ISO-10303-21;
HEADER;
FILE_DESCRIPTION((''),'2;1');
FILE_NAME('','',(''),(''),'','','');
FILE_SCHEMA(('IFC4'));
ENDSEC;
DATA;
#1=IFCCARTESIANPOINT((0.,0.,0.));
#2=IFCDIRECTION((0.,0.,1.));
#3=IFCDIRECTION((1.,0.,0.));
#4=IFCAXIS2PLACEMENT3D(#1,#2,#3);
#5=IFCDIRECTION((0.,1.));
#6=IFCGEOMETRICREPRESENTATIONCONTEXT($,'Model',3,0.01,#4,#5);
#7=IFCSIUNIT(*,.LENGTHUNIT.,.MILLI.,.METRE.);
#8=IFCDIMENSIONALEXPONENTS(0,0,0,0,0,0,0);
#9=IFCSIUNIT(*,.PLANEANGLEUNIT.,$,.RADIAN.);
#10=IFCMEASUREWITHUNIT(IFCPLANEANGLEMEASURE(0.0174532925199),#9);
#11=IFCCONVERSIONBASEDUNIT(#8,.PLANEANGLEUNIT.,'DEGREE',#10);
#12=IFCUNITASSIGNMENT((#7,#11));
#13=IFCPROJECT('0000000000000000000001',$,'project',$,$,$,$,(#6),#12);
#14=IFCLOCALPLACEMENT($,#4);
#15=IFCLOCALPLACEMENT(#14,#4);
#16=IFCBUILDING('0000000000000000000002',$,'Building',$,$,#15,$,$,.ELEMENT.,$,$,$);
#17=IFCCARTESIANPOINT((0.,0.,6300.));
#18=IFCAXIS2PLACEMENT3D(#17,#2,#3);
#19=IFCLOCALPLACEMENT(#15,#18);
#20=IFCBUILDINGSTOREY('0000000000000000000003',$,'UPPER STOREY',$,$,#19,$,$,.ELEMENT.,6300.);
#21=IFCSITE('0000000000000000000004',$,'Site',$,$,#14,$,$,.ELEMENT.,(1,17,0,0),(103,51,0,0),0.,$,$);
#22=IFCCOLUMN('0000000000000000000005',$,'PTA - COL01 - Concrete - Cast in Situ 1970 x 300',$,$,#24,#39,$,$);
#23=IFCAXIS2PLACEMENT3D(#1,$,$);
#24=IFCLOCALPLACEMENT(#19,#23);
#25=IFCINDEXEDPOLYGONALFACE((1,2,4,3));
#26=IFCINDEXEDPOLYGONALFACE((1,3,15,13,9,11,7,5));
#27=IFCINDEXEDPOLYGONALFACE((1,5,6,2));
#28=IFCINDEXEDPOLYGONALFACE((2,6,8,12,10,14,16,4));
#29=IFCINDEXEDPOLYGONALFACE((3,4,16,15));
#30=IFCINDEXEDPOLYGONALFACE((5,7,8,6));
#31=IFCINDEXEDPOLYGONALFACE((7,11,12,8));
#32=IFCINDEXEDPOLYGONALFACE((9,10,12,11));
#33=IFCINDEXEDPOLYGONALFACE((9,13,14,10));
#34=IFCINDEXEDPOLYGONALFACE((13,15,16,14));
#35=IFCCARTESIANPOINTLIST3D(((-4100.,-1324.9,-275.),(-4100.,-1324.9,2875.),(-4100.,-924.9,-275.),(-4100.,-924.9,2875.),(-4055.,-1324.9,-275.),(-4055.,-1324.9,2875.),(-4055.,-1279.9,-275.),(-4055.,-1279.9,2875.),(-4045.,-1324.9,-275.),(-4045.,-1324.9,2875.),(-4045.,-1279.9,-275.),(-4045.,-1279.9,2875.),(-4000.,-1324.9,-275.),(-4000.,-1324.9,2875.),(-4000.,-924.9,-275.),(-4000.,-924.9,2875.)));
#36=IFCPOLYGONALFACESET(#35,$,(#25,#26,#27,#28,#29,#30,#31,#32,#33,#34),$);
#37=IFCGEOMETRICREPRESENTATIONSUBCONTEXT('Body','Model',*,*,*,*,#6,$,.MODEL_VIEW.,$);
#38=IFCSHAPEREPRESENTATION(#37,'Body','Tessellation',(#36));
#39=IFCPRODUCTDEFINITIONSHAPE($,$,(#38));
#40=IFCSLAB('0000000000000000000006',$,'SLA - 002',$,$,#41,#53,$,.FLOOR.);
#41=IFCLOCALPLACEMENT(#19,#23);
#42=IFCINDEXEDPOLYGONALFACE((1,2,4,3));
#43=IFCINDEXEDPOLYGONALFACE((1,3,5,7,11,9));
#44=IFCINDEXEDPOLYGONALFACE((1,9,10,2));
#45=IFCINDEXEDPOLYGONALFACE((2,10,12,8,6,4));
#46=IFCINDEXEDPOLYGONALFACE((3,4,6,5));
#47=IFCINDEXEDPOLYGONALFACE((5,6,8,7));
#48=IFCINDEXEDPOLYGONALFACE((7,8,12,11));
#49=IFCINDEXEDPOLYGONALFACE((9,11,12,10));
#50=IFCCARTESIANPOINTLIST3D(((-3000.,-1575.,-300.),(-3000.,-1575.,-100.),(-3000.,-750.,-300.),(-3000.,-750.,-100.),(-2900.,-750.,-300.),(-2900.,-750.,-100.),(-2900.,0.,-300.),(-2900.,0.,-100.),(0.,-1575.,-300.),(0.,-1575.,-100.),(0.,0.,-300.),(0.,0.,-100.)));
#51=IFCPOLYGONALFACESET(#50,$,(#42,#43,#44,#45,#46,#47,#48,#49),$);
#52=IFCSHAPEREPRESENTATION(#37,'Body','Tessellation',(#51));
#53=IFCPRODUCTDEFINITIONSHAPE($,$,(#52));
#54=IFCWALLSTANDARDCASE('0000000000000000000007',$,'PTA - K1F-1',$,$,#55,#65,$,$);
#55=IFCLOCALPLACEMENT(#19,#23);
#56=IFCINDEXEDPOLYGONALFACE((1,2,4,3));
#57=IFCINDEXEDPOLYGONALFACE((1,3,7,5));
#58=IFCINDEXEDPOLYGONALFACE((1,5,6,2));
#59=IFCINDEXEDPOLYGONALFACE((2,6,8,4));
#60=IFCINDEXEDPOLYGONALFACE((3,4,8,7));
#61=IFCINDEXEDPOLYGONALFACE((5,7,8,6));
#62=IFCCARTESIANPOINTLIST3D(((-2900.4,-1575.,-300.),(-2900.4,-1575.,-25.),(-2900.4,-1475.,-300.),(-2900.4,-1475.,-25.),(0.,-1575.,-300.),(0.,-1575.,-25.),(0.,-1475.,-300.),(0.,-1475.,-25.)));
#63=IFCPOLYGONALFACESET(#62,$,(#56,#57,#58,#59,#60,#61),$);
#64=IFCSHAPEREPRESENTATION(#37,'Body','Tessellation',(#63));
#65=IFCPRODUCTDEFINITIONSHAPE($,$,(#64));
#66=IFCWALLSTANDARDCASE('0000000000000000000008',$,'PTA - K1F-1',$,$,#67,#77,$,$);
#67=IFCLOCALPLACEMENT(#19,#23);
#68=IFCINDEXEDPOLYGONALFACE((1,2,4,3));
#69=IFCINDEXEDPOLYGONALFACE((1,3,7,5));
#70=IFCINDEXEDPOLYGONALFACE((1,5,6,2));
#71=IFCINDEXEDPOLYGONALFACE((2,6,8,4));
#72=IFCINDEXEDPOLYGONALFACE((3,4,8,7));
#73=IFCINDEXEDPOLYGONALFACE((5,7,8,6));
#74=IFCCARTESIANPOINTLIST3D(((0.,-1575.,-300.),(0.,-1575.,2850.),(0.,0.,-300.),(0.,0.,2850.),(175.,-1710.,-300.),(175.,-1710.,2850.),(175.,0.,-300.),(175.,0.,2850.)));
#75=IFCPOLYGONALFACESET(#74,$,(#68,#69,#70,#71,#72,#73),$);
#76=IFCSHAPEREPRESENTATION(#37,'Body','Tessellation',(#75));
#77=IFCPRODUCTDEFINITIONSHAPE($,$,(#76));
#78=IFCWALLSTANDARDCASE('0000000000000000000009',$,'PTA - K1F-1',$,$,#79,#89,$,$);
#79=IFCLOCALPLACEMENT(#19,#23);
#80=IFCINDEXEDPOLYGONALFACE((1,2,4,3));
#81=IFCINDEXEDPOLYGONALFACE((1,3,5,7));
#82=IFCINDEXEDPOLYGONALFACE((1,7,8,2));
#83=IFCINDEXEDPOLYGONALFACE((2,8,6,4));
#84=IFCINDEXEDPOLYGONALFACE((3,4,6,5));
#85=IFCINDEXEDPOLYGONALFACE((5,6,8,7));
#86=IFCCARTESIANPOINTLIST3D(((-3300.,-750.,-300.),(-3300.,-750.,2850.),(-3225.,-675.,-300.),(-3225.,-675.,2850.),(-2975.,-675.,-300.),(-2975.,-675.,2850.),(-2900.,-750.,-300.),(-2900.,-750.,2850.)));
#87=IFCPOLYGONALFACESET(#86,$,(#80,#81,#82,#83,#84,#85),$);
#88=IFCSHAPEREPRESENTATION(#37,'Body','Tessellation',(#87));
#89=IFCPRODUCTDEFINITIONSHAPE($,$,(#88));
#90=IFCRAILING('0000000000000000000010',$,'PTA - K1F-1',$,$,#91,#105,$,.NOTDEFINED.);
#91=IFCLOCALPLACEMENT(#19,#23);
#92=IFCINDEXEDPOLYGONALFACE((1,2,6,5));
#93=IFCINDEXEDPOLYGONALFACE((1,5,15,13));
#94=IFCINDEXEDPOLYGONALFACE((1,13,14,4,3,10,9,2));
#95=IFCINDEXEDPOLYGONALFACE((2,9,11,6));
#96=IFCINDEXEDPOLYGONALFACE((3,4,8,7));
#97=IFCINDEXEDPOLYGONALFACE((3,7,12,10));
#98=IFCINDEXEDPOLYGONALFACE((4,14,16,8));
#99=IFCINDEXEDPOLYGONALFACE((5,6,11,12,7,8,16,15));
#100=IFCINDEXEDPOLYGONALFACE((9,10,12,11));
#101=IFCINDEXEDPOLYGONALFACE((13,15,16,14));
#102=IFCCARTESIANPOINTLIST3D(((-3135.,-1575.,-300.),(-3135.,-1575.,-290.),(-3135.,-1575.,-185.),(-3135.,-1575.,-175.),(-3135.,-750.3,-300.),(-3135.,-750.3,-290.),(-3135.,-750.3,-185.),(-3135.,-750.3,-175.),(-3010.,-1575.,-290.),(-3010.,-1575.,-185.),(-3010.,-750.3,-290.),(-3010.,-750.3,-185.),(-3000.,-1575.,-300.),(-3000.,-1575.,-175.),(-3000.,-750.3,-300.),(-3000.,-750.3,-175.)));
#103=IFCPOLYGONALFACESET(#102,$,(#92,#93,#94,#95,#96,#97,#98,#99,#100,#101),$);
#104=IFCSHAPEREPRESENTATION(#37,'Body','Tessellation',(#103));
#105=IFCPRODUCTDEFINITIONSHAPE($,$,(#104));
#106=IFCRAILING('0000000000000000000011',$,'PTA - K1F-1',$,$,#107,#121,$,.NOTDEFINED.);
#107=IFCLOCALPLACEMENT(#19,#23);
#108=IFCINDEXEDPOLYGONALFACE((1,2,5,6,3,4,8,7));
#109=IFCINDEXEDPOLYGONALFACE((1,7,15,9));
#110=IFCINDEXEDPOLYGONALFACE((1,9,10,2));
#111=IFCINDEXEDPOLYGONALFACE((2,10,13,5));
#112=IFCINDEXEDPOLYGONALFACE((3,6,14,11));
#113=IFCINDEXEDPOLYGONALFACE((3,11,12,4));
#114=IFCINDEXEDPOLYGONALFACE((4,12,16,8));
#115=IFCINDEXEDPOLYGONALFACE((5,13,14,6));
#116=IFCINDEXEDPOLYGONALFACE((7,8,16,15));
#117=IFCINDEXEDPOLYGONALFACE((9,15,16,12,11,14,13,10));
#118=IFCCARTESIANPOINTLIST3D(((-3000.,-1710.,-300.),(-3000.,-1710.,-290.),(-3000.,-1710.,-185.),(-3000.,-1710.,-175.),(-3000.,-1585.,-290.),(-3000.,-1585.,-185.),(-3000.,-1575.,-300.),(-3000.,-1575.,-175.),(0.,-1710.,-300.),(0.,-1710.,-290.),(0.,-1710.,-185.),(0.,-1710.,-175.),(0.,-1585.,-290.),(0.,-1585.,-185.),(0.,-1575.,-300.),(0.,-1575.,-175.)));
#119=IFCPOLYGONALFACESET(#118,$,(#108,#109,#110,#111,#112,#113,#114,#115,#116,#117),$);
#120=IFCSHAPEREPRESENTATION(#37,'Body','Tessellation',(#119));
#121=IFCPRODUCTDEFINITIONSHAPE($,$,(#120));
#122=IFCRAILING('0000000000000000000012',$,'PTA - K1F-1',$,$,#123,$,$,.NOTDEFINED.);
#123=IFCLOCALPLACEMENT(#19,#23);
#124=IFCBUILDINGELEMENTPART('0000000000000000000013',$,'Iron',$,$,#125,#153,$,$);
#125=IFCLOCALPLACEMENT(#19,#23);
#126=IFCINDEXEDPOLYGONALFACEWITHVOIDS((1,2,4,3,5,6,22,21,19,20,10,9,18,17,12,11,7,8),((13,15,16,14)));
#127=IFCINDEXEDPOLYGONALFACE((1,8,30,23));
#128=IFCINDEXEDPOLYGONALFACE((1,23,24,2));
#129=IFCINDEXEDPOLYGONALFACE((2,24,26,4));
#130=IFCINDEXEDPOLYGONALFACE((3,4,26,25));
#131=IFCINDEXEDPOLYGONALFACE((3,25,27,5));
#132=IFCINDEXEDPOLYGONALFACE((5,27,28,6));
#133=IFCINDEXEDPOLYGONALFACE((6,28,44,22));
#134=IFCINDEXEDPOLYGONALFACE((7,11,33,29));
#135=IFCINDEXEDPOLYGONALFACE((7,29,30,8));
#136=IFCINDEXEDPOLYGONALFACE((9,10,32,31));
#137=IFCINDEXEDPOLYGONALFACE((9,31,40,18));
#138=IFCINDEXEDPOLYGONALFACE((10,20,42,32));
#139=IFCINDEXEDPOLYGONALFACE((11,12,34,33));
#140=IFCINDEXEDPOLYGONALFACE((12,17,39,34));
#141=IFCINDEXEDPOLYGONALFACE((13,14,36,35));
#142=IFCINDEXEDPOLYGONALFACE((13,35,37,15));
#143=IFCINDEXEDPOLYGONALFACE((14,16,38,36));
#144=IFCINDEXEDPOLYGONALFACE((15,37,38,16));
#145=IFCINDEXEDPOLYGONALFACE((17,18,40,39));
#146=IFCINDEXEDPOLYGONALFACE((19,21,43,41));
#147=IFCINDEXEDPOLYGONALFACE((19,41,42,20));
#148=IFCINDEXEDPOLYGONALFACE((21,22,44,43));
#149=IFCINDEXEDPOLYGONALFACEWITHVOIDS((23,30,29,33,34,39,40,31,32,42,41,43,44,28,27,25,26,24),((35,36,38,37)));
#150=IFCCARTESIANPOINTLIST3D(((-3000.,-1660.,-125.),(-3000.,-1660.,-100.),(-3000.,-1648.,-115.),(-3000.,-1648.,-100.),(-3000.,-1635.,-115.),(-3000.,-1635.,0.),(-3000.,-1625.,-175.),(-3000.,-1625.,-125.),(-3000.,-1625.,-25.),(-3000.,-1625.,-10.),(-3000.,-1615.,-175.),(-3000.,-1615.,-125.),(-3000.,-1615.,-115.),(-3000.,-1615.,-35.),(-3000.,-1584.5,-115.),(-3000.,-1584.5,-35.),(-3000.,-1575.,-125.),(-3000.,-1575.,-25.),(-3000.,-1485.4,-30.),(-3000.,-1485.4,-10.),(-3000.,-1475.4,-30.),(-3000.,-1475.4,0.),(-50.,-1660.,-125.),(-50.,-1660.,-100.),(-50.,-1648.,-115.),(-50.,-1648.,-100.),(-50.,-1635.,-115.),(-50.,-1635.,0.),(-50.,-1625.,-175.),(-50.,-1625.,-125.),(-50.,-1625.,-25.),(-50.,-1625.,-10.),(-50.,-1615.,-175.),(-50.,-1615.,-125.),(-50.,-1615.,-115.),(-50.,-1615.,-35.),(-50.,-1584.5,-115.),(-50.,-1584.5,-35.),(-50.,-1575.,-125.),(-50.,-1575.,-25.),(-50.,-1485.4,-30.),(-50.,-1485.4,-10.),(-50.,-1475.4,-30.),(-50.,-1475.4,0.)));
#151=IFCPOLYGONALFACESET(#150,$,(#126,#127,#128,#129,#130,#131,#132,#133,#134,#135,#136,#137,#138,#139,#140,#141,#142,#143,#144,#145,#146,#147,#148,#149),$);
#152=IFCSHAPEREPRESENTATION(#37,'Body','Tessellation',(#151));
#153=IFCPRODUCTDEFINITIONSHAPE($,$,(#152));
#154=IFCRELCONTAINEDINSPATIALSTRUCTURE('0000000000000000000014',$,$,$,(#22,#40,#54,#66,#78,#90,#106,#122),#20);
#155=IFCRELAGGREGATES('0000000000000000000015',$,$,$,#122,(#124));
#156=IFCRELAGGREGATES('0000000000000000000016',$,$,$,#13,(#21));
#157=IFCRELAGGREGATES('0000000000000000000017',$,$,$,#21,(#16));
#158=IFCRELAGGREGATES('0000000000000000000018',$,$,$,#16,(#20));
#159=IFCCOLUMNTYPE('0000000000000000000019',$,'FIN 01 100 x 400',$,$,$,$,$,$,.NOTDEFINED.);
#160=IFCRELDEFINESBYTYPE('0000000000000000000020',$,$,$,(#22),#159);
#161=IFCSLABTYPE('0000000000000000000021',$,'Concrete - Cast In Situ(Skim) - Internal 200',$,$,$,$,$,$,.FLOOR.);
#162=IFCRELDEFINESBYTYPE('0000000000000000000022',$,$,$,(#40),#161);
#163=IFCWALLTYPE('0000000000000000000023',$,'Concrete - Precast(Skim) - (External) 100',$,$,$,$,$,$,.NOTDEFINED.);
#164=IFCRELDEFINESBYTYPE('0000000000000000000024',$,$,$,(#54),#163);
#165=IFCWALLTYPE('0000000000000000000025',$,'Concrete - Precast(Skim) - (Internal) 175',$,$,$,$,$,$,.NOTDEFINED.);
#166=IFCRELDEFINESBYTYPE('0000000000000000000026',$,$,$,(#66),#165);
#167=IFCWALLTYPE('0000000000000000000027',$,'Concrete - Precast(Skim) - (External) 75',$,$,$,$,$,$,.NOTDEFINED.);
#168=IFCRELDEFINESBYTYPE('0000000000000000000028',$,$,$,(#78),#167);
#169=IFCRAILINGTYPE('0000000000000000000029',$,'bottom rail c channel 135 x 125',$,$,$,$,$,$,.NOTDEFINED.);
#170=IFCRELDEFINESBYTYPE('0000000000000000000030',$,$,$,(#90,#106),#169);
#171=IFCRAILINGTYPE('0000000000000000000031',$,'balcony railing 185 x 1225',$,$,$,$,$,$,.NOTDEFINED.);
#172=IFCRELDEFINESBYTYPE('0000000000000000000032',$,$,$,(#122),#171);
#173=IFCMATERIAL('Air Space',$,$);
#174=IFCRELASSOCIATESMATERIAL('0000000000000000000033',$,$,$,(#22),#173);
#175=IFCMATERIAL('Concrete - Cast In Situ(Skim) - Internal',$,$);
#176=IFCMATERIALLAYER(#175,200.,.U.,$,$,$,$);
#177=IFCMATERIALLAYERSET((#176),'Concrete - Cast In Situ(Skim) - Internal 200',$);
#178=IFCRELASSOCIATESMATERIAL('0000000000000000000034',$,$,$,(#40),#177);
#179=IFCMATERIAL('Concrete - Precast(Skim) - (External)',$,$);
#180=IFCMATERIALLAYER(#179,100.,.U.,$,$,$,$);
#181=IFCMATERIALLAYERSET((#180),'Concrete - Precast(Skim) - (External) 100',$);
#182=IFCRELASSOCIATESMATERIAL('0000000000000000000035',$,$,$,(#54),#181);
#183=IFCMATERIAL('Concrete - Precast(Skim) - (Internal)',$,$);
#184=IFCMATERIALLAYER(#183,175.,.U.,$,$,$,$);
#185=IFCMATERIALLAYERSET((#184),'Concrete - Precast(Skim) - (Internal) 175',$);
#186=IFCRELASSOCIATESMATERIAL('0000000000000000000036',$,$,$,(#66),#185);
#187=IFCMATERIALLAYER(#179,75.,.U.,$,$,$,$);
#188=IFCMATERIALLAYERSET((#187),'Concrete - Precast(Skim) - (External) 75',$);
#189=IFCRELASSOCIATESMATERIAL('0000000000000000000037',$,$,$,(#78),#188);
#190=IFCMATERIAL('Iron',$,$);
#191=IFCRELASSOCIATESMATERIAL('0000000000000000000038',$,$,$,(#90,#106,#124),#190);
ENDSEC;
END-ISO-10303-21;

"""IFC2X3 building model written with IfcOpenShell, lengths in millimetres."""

from ifc_helpers import new_model, entity, si_unit, converted_unit, direction, frame, origin_with_axes, place, context, subcontext, project, spatial, polyline, outline, extrude, material, layer, layer_set, layer_usage, type_object, element, aggregate, save


model = new_model("IFC2X3")

# Units and contexts
model_context = context("Model", 3, precision=0.01, world=origin_with_axes(), true_north=direction((0.0, 1.0)))
body_context = subcontext(model_context, "Body", "Model", "MODEL_VIEW")
ifc_project = project(units=[si_unit("LENGTHUNIT", "METRE", prefix="MILLI"), converted_unit("PLANEANGLEUNIT", "DEGREE", entity("IfcPlaneAngleMeasure", 0.0174532925199), si_unit("PLANEANGLEUNIT", "RADIAN"), dimensions=[0, 0, 0, 0, 0, 0, 0])], contexts=[model_context])

# Site, building, storey
site_placement = place(None, origin_with_axes())
site = spatial("IfcSite", under=ifc_project, at=site_placement, Name="Site", CompositionType="ELEMENT", RefLatitude=(1, 17, 0, 0), RefLongitude=(103, 51, 0, 0), RefElevation=0.0)
building_placement = place(site_placement, origin_with_axes())
building = spatial("IfcBuilding", under=site, at=building_placement, Name="Building", CompositionType="ELEMENT")
storey_placement = place(building_placement, frame((0.0, 0.0, 6300.0), z_axis=(0.0, 0.0, 1.0), x_axis=(1.0, 0.0, 0.0)))
storey = spatial("IfcBuildingStorey", under=building, at=storey_placement, Name="UPPER STOREY", CompositionType="ELEMENT", Elevation=6300.0)

# Column
ifc_material_1 = material(Name="Air Space")
column_type = type_object("IfcColumnType", Name="FIN 01 100 x 400", PredefinedType="NOTDEFINED")
column_placement = place(storey_placement, frame((-4049.9, -1324.9, -275.0), z_axis=(0.0, 0.0, 1.0), x_axis=(-1.0, 0.0, 0.0)))
element("IfcColumn", 1, at=column_placement, inside=storey, type_object=column_type, material=ifc_material_1, Name="PTA - COL01 - Concrete - Cast in Situ 1970 x 300", context=body_context, shape_type="SweptSolid", body=[
    extrude(outline(polyline([(-50.0, 0.0), (-50.0, -400.0), (50.0, -400.0), (50.0, 0.0), (5.0, 0.0), (5.0, -45.0), (-5.0, -45.0), (-5.0, 0.0), (-50.0, 0.0)])), frame((0.0, 0.0, 0.0), z_axis=(0.0, 0.0, -1.0), x_axis=(-1.0, 0.0, 0.0)), (0.0, 0.0, -1.0), 3150.0),
])

# Slab
ifc_material_2 = material(Name="Concrete - Cast In Situ(Skim) - Internal")
ifc_layer_1 = layer(ifc_material_2, 200.0, ventilated="UNKNOWN")
ifc_layer_set_1 = layer_set([ifc_layer_1], Name="Concrete - Cast In Situ(Skim) - Internal 200")
ifc_layer_usage_1 = layer_usage(ifc_layer_set_1, "AXIS3", "NEGATIVE", 200.0)
slab_type = type_object("IfcSlabType", Name="Concrete - Cast In Situ(Skim) - Internal 200", PredefinedType="FLOOR")
slab_placement = place(storey_placement, frame((-3000.0, -750.0, -100.0), z_axis=(0.0, 0.0, 1.0), x_axis=(1.0, 0.0, 0.0)))
element("IfcSlab", 2, at=slab_placement, inside=storey, type_object=slab_type, material=ifc_layer_usage_1, Name="SLA - 002", PredefinedType="FLOOR", context=body_context, shape_type="SweptSolid", body=[
    extrude(outline(polyline([(0.0, 0.0), (0.0, -825.0), (3000.0, -825.0), (3000.0, 750.0), (100.0, 750.0), (100.0, 0.0), (0.0, 0.0)])), frame((0.0, 0.0, -200.0), z_axis=(0.0, 0.0, 1.0), x_axis=(1.0, 0.0, 0.0)), (0.0, 0.0, 1.0), 200.0),
])

# Walls
ifc_material_3 = material(Name="Concrete - Precast(Skim) - (External)")
ifc_layer_2 = layer(ifc_material_3, 100.0, ventilated="UNKNOWN")
ifc_layer_set_2 = layer_set([ifc_layer_2], Name="Concrete - Precast(Skim) - (External) 100")
ifc_layer_usage_2 = layer_usage(ifc_layer_set_2, "AXIS2", "NEGATIVE", 0.0)
wall_type_1 = type_object("IfcWallType", Name="Concrete - Precast(Skim) - (External) 100", PredefinedType="NOTDEFINED")
wall_1_placement = place(storey_placement, frame((0.0, -1575.0, -300.0), z_axis=(0.0, 0.0, 1.0), x_axis=(-1.0, 0.0, 0.0)))
element("IfcWallStandardCase", 3, at=wall_1_placement, inside=storey, type_object=wall_type_1, material=ifc_layer_usage_2, Name="PTA - K1F-1", context=body_context, shape_type="SweptSolid", body=[
    extrude(outline(polyline([(0.0, -100.0), (2900.4, -100.0), (2900.4, 0.0), (0.0, 0.0), (0.0, -100.0)])), origin_with_axes(), (0.0, 0.0, 1.0), 275.0),
])
ifc_material_4 = material(Name="Concrete - Precast(Skim) - (Internal)")
ifc_layer_3 = layer(ifc_material_4, 175.0, ventilated="UNKNOWN")
ifc_layer_set_3 = layer_set([ifc_layer_3], Name="Concrete - Precast(Skim) - (Internal) 175")
ifc_layer_usage_3 = layer_usage(ifc_layer_set_3, "AXIS2", "NEGATIVE", 0.0)
wall_type_2 = type_object("IfcWallType", Name="Concrete - Precast(Skim) - (Internal) 175", PredefinedType="NOTDEFINED")
wall_2_placement = place(storey_placement, frame((0.0, -1575.0, -300.0), z_axis=(0.0, 0.0, 1.0), x_axis=(0.0, 1.0, 0.0)))
element("IfcWallStandardCase", 4, at=wall_2_placement, inside=storey, type_object=wall_type_2, material=ifc_layer_usage_3, Name="PTA - K1F-1", context=body_context, shape_type="SweptSolid", body=[
    extrude(outline(polyline([(-135.0, -175.0), (1575.0, -175.0), (1575.0, 0.0), (0.0, 0.0), (-135.0, -175.0)])), origin_with_axes(), (0.0, 0.0, 1.0), 3150.0),
])
ifc_layer_4 = layer(ifc_material_3, 75.0, ventilated="UNKNOWN")
ifc_layer_set_4 = layer_set([ifc_layer_4], Name="Concrete - Precast(Skim) - (External) 75")
ifc_layer_usage_4 = layer_usage(ifc_layer_set_4, "AXIS2", "POSITIVE", 0.0)
wall_type_3 = type_object("IfcWallType", Name="Concrete - Precast(Skim) - (External) 75", PredefinedType="NOTDEFINED")
wall_3_placement = place(storey_placement, frame((-3300.0, -750.0, -300.0), z_axis=(0.0, 0.0, 1.0), x_axis=(1.0, 0.0, 0.0)))
element("IfcWallStandardCase", 5, at=wall_3_placement, inside=storey, type_object=wall_type_3, material=ifc_layer_usage_4, Name="PTA - K1F-1", context=body_context, shape_type="SweptSolid", body=[
    extrude(outline(polyline([(0.0, 0.0), (400.0, 0.0), (325.0, 75.0), (75.0, 75.0), (0.0, 0.0)])), origin_with_axes(), (0.0, 0.0, 1.0), 3150.0),
])

# Railings
ifc_material_5 = material(Name="Iron")
railing_type_1 = type_object("IfcRailingType", Name="bottom rail c channel 135 x 125", PredefinedType="NOTDEFINED")
railing_1_placement = place(storey_placement, frame((-3000.0, -750.3, -175.0), z_axis=(0.0, 0.0, 1.0), x_axis=(0.0, -1.0, 0.0)))
element("IfcRailing", 6, at=railing_1_placement, inside=storey, type_object=railing_type_1, material=ifc_material_5, Name="PTA - K1F-1", PredefinedType="NOTDEFINED", context=body_context, shape_type="SweptSolid", body=[
    extrude(outline(polyline([(0.0, 0.0), (0.0, -125.0), (135.0, -125.0), (135.0, -115.0), (10.0, -115.0), (10.0, -10.0), (135.0, -10.0), (135.0, 0.0), (0.0, 0.0)])), frame((0.0, 0.0, 0.0), z_axis=(-1.0, 0.0, 0.0), x_axis=(0.0, -1.0, 0.0)), (0.0, 0.0, -1.0), 824.7),
])
railing_2_placement = place(storey_placement, frame((-3000.0, -1575.0, -175.0), z_axis=(0.0, 0.0, 1.0), x_axis=(1.0, 0.0, 0.0)))
element("IfcRailing", 7, at=railing_2_placement, inside=storey, type_object=railing_type_1, material=ifc_material_5, Name="PTA - K1F-1", PredefinedType="NOTDEFINED", context=body_context, shape_type="SweptSolid", body=[
    extrude(outline(polyline([(0.0, 0.0), (0.0, -125.0), (135.0, -125.0), (135.0, -115.0), (10.0, -115.0), (10.0, -10.0), (135.0, -10.0), (135.0, 0.0), (0.0, 0.0)])), frame((0.0, 0.0, 0.0), z_axis=(-1.0, 0.0, 0.0), x_axis=(0.0, -1.0, 0.0)), (0.0, 0.0, -1.0), 3000.0),
])

# Railing, building element part
railing_type_2 = type_object("IfcRailingType", Name="balcony railing 185 x 1225", PredefinedType="NOTDEFINED")
railing_3_placement = place(storey_placement, frame((-50.0, -1575.0, -175.0), z_axis=(0.0, 0.0, 1.0), x_axis=(-1.0, 0.0, 0.0)))
railing_3 = element("IfcRailing", 8, at=railing_3_placement, inside=storey, type_object=railing_type_2, Name="PTA - K1F-1", PredefinedType="NOTDEFINED")
building_element_part_1_placement = place(railing_3_placement, origin_with_axes())
building_element_part_1 = element("IfcBuildingElementPart", 9, at=building_element_part_1_placement, material=ifc_material_5, Name="Iron", context=body_context, shape_type="SweptSolid", body=[
    extrude(outline(polyline([(0.0, 150.0), (0.0, 50.0), (40.0, 50.0), (40.0, 0.0), (50.0, 0.0), (50.0, 50.0), (85.0, 50.0), (85.0, 75.0), (73.0, 75.0), (73.0, 60.0), (60.0, 60.0), (60.0, 175.0), (-99.6, 175.0), (-99.6, 145.0), (-89.6, 145.0), (-89.6, 165.0), (50.0, 165.0), (50.0, 150.0), (0.0, 150.0)]), holes=[polyline([(9.5, 140.0), (40.0, 140.0), (40.0, 60.0), (9.5, 60.0), (9.5, 140.0)])]), frame((0.0, 0.0, 0.0), z_axis=(1.0, 0.0, 0.0), x_axis=(0.0, 1.0, 0.0)), (0.0, 0.0, 1.0), 2950.0),
])
aggregate(railing_3, [building_element_part_1])

save(model, "model.ifc")
